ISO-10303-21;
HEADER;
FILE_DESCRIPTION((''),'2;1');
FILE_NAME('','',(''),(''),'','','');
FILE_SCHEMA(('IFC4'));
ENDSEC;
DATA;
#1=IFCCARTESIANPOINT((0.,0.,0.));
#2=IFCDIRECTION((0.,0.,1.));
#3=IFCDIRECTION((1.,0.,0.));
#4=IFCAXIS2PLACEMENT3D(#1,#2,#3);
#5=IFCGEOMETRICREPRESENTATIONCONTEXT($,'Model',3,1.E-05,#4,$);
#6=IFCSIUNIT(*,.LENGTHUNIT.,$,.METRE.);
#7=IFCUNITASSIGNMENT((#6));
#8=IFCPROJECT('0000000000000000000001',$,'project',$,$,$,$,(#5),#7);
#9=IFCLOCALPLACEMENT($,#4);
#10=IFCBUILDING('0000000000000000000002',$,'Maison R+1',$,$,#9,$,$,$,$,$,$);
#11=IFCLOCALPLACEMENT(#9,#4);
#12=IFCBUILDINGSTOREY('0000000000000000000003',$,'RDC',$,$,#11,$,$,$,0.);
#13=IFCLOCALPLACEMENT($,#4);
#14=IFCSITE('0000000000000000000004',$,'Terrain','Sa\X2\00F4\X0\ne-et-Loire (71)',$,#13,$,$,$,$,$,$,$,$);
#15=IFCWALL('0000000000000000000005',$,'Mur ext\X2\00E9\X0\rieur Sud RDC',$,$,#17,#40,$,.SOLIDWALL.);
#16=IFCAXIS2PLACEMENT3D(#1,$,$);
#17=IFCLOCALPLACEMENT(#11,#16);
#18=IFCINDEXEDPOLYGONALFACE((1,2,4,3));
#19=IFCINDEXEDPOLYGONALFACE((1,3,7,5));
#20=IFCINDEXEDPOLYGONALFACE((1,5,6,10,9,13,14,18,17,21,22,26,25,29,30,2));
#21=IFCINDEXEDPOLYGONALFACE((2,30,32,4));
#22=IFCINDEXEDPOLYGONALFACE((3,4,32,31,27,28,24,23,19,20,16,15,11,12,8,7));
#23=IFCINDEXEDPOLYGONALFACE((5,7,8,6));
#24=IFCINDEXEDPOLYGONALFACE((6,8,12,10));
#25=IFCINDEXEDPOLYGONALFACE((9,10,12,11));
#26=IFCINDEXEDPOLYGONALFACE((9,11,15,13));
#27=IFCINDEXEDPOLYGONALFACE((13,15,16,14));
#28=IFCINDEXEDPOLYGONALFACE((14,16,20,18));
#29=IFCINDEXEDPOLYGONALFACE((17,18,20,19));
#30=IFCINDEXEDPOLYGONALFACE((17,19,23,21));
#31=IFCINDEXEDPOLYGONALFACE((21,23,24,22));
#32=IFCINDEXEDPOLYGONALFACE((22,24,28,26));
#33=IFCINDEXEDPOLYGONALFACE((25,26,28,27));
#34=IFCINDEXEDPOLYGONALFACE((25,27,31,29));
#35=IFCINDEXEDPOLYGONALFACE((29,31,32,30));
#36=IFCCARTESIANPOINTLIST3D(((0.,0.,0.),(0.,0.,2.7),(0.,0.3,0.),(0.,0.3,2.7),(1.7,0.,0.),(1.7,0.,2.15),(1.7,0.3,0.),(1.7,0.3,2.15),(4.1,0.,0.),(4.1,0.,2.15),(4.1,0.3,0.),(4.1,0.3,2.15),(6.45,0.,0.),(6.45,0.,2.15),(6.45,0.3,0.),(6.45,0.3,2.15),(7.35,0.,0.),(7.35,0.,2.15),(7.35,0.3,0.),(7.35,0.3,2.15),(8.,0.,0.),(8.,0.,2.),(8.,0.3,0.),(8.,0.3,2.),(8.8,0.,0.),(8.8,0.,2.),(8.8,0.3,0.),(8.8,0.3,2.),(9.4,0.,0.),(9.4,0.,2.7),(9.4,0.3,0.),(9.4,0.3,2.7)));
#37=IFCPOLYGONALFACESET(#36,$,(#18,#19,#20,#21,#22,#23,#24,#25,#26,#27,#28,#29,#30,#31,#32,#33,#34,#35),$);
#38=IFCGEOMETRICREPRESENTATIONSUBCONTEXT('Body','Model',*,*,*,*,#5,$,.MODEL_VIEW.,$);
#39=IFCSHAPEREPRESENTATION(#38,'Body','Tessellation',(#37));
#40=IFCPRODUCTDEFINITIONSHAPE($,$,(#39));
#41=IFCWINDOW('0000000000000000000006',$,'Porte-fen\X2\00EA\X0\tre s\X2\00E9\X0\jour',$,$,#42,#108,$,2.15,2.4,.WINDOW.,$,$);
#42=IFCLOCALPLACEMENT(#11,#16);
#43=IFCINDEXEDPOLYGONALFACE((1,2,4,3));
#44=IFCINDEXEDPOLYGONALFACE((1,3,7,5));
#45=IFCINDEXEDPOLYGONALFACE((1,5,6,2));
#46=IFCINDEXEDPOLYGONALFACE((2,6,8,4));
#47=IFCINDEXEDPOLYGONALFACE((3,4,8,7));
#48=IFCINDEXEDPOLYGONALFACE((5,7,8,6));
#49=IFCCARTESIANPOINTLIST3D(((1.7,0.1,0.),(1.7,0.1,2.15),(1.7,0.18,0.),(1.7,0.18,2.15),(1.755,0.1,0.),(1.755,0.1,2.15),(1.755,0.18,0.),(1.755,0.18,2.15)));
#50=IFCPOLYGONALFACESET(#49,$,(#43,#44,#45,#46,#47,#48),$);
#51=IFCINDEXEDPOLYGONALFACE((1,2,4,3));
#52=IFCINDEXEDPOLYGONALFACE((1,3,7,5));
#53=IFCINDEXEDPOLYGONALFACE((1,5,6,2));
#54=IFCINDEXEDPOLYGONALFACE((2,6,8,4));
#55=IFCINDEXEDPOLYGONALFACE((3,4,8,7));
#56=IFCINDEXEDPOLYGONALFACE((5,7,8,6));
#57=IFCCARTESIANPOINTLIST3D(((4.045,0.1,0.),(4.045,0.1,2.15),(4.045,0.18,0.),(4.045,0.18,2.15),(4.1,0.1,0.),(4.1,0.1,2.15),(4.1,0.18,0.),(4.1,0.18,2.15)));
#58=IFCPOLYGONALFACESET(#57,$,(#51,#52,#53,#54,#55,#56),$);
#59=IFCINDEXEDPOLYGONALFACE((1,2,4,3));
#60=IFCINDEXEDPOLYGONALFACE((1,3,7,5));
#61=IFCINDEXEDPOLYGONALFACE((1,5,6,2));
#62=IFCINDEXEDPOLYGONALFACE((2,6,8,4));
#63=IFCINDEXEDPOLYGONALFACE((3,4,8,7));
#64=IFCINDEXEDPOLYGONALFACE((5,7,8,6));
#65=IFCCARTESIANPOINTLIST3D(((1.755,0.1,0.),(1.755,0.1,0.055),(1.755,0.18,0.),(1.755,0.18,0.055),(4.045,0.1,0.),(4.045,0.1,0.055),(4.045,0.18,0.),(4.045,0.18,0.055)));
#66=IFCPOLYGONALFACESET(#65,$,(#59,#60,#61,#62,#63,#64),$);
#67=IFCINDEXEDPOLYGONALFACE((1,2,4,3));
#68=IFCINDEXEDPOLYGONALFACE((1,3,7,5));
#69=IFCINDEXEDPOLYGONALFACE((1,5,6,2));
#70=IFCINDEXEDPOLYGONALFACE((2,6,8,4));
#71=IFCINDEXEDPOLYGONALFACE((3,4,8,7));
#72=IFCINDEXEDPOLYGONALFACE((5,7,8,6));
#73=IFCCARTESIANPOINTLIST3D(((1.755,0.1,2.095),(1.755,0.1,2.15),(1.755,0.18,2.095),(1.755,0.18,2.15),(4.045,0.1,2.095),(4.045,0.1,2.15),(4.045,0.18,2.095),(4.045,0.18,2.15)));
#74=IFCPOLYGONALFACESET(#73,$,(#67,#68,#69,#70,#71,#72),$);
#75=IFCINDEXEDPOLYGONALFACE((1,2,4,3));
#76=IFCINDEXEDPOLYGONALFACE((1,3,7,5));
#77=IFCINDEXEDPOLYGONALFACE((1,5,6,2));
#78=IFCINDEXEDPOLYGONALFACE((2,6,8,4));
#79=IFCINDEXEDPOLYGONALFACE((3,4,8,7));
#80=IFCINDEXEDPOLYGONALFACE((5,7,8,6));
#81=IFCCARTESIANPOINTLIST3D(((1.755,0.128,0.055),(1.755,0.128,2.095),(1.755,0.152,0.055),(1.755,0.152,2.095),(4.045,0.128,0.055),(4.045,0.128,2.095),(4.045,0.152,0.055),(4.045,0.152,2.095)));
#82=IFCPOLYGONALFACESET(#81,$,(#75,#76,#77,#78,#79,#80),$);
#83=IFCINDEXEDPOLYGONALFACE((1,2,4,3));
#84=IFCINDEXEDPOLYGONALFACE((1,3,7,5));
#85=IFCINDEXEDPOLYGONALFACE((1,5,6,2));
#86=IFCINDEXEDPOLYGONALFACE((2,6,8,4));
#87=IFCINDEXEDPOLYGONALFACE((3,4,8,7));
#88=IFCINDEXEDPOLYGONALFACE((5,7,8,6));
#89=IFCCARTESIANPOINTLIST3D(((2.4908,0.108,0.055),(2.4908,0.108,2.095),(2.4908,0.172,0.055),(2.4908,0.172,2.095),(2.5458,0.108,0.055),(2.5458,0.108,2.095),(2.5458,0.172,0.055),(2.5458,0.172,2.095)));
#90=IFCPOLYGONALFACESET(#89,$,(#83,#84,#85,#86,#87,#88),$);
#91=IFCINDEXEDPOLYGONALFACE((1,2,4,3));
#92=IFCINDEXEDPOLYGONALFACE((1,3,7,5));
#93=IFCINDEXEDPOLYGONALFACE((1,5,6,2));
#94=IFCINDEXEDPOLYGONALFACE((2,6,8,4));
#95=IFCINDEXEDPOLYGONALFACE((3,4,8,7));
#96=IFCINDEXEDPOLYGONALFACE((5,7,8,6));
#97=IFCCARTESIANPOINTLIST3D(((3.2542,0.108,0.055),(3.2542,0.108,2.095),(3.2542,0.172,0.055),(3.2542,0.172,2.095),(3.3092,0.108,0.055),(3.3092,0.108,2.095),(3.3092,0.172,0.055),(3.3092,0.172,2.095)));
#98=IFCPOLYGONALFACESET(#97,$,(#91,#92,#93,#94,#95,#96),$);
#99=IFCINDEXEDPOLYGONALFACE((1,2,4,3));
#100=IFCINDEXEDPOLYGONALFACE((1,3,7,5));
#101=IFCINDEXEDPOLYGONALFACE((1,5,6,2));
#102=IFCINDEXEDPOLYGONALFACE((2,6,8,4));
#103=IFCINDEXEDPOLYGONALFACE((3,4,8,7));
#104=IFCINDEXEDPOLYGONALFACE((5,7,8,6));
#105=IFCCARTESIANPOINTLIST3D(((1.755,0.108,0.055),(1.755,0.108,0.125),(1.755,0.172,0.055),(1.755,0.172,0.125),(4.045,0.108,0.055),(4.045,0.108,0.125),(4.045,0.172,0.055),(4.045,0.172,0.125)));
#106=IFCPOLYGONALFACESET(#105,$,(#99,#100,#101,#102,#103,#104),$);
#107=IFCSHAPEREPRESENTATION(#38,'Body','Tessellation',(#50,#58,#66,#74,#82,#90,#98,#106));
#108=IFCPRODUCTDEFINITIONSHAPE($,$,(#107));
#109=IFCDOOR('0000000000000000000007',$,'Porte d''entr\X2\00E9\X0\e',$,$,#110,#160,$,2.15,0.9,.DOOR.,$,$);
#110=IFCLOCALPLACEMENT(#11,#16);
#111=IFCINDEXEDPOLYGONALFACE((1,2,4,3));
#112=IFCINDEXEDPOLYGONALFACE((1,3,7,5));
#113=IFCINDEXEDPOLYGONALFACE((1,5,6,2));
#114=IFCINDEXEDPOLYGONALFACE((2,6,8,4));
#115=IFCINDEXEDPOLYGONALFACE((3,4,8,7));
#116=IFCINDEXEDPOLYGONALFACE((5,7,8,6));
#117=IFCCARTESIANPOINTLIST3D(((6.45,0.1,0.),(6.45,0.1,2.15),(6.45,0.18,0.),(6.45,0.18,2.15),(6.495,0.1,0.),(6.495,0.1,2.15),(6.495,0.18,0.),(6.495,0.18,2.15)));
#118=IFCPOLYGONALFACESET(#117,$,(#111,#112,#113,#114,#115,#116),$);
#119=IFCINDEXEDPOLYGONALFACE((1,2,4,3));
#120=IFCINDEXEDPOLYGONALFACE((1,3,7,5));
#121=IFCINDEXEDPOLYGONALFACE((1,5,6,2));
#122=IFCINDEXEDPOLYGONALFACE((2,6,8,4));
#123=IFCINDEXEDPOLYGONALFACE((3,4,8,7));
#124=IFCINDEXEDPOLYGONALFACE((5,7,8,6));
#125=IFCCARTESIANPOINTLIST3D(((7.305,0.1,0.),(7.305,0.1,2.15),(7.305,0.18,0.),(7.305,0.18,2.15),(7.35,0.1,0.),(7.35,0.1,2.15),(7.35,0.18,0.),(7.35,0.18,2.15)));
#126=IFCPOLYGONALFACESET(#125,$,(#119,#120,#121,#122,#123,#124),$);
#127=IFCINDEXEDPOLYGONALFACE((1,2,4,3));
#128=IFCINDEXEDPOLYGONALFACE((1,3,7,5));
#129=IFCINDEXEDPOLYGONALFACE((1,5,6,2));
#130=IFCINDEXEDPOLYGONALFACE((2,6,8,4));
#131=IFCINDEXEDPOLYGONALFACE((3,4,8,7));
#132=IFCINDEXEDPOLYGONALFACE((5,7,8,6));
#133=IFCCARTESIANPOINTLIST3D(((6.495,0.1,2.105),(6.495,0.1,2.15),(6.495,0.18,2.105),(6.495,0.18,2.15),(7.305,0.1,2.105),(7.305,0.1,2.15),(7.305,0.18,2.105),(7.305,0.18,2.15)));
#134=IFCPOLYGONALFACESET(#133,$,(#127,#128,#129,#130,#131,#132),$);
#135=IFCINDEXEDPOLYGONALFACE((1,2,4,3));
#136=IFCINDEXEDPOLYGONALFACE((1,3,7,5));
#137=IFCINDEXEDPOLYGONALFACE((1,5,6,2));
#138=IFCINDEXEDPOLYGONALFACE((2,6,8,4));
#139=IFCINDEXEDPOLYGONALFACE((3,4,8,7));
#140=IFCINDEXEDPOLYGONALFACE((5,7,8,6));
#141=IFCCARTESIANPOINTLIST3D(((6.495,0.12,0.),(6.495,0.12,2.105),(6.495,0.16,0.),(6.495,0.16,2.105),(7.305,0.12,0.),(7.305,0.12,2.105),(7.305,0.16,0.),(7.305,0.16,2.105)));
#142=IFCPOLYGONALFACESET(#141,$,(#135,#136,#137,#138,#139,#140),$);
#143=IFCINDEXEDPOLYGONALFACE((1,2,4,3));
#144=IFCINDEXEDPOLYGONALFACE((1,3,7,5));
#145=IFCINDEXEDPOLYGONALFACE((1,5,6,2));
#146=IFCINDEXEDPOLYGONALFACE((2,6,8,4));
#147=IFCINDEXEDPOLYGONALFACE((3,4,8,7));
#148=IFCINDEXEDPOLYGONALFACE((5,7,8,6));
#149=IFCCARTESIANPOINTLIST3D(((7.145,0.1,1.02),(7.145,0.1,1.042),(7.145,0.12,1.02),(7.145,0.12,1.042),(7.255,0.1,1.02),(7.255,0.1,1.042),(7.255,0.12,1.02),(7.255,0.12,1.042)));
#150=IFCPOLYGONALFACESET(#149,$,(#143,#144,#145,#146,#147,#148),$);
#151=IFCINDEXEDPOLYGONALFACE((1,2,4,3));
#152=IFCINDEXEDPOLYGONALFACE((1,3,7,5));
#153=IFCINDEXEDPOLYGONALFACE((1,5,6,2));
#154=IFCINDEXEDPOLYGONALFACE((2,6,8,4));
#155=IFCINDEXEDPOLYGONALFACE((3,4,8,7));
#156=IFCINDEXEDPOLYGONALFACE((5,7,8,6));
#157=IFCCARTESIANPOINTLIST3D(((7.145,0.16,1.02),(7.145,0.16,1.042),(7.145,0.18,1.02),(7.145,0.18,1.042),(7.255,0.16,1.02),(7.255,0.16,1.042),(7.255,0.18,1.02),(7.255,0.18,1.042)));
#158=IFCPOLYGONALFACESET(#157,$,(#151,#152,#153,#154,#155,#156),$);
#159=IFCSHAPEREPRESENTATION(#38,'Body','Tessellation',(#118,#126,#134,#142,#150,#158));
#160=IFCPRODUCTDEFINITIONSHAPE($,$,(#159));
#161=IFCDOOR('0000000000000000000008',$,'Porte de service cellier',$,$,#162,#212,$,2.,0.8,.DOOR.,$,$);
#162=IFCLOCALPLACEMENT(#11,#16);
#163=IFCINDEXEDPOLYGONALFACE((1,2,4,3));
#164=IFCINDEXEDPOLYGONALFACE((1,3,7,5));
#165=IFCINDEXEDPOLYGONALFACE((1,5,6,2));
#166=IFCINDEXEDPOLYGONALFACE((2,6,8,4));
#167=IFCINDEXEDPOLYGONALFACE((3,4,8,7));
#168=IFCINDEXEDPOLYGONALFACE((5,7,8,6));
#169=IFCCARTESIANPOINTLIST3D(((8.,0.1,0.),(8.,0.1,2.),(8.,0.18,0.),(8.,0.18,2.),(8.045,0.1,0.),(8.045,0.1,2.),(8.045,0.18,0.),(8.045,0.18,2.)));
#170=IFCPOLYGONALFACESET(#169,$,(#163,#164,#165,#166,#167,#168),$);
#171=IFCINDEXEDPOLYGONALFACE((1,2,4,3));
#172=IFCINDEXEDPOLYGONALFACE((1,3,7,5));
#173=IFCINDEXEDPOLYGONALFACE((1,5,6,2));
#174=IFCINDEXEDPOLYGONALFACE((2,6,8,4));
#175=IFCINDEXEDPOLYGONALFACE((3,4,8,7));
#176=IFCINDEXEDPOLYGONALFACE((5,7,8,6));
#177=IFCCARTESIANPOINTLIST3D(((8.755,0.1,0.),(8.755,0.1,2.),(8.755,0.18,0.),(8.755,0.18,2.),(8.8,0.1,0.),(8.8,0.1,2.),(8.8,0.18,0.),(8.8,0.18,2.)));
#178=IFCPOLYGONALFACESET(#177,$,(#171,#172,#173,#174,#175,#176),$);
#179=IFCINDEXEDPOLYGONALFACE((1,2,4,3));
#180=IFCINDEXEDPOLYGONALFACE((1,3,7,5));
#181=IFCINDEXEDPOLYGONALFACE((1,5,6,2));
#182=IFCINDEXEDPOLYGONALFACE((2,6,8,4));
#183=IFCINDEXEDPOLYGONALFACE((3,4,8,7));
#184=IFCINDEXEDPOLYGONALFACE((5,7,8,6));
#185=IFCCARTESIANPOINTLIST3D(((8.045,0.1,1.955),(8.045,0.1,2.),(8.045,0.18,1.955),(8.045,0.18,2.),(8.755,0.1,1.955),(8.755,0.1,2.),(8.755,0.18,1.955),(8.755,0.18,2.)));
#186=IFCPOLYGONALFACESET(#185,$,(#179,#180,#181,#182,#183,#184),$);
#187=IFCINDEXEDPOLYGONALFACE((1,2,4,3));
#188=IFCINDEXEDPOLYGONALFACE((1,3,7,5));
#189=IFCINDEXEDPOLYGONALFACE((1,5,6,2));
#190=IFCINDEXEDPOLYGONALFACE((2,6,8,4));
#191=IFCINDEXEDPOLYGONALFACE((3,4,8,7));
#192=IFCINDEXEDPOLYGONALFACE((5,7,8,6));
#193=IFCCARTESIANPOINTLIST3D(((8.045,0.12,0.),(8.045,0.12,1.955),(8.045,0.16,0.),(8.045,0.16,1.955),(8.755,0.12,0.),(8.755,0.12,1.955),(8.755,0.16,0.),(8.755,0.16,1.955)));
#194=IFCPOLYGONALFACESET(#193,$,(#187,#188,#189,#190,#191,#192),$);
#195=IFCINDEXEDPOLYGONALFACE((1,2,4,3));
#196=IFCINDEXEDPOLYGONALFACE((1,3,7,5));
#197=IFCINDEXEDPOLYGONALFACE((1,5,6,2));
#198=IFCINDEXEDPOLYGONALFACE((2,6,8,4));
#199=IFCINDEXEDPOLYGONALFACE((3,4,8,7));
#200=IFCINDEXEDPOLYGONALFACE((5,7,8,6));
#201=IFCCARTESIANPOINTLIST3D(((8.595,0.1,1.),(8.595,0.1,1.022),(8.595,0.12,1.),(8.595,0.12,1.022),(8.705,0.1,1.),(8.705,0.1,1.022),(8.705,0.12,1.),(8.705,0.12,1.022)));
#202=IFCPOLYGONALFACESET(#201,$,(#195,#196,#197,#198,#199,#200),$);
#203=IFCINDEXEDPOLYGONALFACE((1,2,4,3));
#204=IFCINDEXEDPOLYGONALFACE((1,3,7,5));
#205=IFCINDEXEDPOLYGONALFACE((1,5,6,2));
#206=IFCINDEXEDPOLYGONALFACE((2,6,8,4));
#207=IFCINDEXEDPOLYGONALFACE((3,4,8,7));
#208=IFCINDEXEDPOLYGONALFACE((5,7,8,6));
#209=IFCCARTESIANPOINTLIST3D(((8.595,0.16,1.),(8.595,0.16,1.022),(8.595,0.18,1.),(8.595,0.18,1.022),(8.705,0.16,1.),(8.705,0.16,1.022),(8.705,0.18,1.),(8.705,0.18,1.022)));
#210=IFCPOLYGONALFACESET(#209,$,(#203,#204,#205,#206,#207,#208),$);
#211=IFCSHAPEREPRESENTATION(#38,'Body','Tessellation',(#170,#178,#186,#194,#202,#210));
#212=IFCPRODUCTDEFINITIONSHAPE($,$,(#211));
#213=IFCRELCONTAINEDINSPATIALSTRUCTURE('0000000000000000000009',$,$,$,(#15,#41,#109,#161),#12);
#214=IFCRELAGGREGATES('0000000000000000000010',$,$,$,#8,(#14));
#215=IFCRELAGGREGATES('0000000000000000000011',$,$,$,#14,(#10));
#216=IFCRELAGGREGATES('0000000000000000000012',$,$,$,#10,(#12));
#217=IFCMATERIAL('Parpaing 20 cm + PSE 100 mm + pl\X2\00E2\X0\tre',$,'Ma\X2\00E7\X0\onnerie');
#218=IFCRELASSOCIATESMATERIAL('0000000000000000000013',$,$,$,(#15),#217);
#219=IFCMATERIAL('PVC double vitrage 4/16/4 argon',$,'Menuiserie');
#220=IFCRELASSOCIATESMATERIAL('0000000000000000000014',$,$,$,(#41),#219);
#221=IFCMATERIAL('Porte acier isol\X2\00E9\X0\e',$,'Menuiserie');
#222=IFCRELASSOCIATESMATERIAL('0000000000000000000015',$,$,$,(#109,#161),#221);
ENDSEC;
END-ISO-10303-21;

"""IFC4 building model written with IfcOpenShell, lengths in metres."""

from ifc_helpers import new_model, si_unit, frame, frame_2d, origin_with_axes, place, context, subcontext, project, spatial, rectangle, extrude, material, element, fill, save


model = new_model("IFC4")

# Units and contexts
model_context = context("Model", 3, precision=1e-05, world=origin_with_axes())
body_context = subcontext(model_context, "Body", "Model", "MODEL_VIEW")
ifc_project = project(units=[si_unit("LENGTHUNIT", "METRE")], contexts=[model_context])

# Site, building, storey
site_placement = place(None, origin_with_axes())
site = spatial("IfcSite", under=ifc_project, at=site_placement, Name="Terrain", Description="Saône-et-Loire (71)")
building_placement = place(None, origin_with_axes())
building = spatial("IfcBuilding", under=site, at=building_placement, Name="Maison R+1")
storey_placement = place(building_placement, origin_with_axes())
storey = spatial("IfcBuildingStorey", under=building, at=storey_placement, Name="RDC", Elevation=0.0)

# Wall, openings, window, doors
ifc_material_1 = material(Name="Parpaing 20 cm + PSE 100 mm + plâtre", Category="Maçonnerie")
wall_1_placement = place(storey_placement, origin_with_axes())
wall_1 = element("IfcWall", 1, at=wall_1_placement, inside=storey, material=ifc_material_1, Name="Mur extérieur Sud RDC", PredefinedType="SOLIDWALL", context=body_context, shape_type="SweptSolid", body=[
    extrude(rectangle(XDim=9.4, YDim=0.3, at=frame_2d((4.7, 0.15))), origin_with_axes(), (0.0, 0.0, 1.0), 2.7),
])
opening_1_placement = place(storey_placement, frame((1.7, -0.05, 0.0), z_axis=(0.0, 0.0, 1.0), x_axis=(1.0, 0.0, 0.0)))
opening_1 = element("IfcOpeningElement", 2, at=opening_1_placement, cuts=wall_1, context=body_context, shape_type="SweptSolid", body=[
    extrude(rectangle(XDim=2.4, YDim=0.4, at=frame_2d((1.2, 0.2))), origin_with_axes(), (0.0, 0.0, 1.0), 2.15),
])
opening_2_placement = place(storey_placement, frame((6.45, -0.05, 0.0), z_axis=(0.0, 0.0, 1.0), x_axis=(1.0, 0.0, 0.0)))
opening_2 = element("IfcOpeningElement", 3, at=opening_2_placement, cuts=wall_1, context=body_context, shape_type="SweptSolid", body=[
    extrude(rectangle(XDim=0.9, YDim=0.4, at=frame_2d((0.45, 0.2))), origin_with_axes(), (0.0, 0.0, 1.0), 2.15),
])
opening_3_placement = place(storey_placement, frame((8.0, -0.05, 0.0), z_axis=(0.0, 0.0, 1.0), x_axis=(1.0, 0.0, 0.0)))
opening_3 = element("IfcOpeningElement", 4, at=opening_3_placement, cuts=wall_1, context=body_context, shape_type="SweptSolid", body=[
    extrude(rectangle(XDim=0.8, YDim=0.4, at=frame_2d((0.4, 0.2))), origin_with_axes(), (0.0, 0.0, 1.0), 2.0),
])
ifc_material_2 = material(Name="PVC double vitrage 4/16/4 argon", Category="Menuiserie")
window_1_placement = place(storey_placement, frame((1.7, 0.1, 0.0), z_axis=(0.0, 0.0, 1.0), x_axis=(1.0, 0.0, 0.0)))
window_1 = element("IfcWindow", 5, at=window_1_placement, inside=storey, material=ifc_material_2, Name="Porte-fenêtre séjour", OverallHeight=2.15, OverallWidth=2.4, PredefinedType="WINDOW", context=body_context, shape_type="SweptSolid", body=[
    extrude(rectangle(XDim=0.055, YDim=0.08, at=frame_2d((0.0275, 0.04))), origin_with_axes(), (0.0, 0.0, 1.0), 2.15),
    extrude(rectangle(XDim=0.055, YDim=0.08, at=frame_2d((0.0275, 0.04))), frame((2.345, 0.0, 0.0), z_axis=(0.0, 0.0, 1.0), x_axis=(1.0, 0.0, 0.0)), (0.0, 0.0, 1.0), 2.15),
    extrude(rectangle(XDim=2.29, YDim=0.08, at=frame_2d((1.145, 0.04))), frame((0.055, 0.0, 0.0), z_axis=(0.0, 0.0, 1.0), x_axis=(1.0, 0.0, 0.0)), (0.0, 0.0, 1.0), 0.055),
    extrude(rectangle(XDim=2.29, YDim=0.08, at=frame_2d((1.145, 0.04))), frame((0.055, 0.0, 2.095), z_axis=(0.0, 0.0, 1.0), x_axis=(1.0, 0.0, 0.0)), (0.0, 0.0, 1.0), 0.055),
    extrude(rectangle(XDim=2.29, YDim=0.024, at=frame_2d((1.145, 0.012))), frame((0.055, 0.028, 0.055), z_axis=(0.0, 0.0, 1.0), x_axis=(1.0, 0.0, 0.0)), (0.0, 0.0, 1.0), 2.04),
    extrude(rectangle(XDim=0.055, YDim=0.064, at=frame_2d((0.0275, 0.032))), frame((0.7908, 0.008, 0.055), z_axis=(0.0, 0.0, 1.0), x_axis=(1.0, 0.0, 0.0)), (0.0, 0.0, 1.0), 2.04),
    extrude(rectangle(XDim=0.055, YDim=0.064, at=frame_2d((0.0275, 0.032))), frame((1.5542, 0.008, 0.055), z_axis=(0.0, 0.0, 1.0), x_axis=(1.0, 0.0, 0.0)), (0.0, 0.0, 1.0), 2.04),
    extrude(rectangle(XDim=2.29, YDim=0.064, at=frame_2d((1.145, 0.032))), frame((0.055, 0.008, 0.055), z_axis=(0.0, 0.0, 1.0), x_axis=(1.0, 0.0, 0.0)), (0.0, 0.0, 1.0), 0.07),
])
fill(opening_1, window_1)
ifc_material_3 = material(Name="Porte acier isolée", Category="Menuiserie")
door_1_placement = place(storey_placement, frame((6.45, 0.1, 0.0), z_axis=(0.0, 0.0, 1.0), x_axis=(1.0, 0.0, 0.0)))
door_1 = element("IfcDoor", 6, at=door_1_placement, inside=storey, material=ifc_material_3, Name="Porte d'entrée", OverallHeight=2.15, OverallWidth=0.9, PredefinedType="DOOR", context=body_context, shape_type="SweptSolid", body=[
    extrude(rectangle(XDim=0.045, YDim=0.08, at=frame_2d((0.0225, 0.04))), origin_with_axes(), (0.0, 0.0, 1.0), 2.15),
    extrude(rectangle(XDim=0.045, YDim=0.08, at=frame_2d((0.0225, 0.04))), frame((0.855, 0.0, 0.0), z_axis=(0.0, 0.0, 1.0), x_axis=(1.0, 0.0, 0.0)), (0.0, 0.0, 1.0), 2.15),
    extrude(rectangle(XDim=0.81, YDim=0.08, at=frame_2d((0.405, 0.04))), frame((0.045, 0.0, 2.105), z_axis=(0.0, 0.0, 1.0), x_axis=(1.0, 0.0, 0.0)), (0.0, 0.0, 1.0), 0.045),
    extrude(rectangle(XDim=0.81, YDim=0.04, at=frame_2d((0.405, 0.02))), frame((0.045, 0.02, 0.0), z_axis=(0.0, 0.0, 1.0), x_axis=(1.0, 0.0, 0.0)), (0.0, 0.0, 1.0), 2.105),
    extrude(rectangle(XDim=0.11, YDim=0.02, at=frame_2d((0.055, 0.01))), frame((0.695, 0.0, 1.02), z_axis=(0.0, 0.0, 1.0), x_axis=(1.0, 0.0, 0.0)), (0.0, 0.0, 1.0), 0.022),
    extrude(rectangle(XDim=0.11, YDim=0.02, at=frame_2d((0.055, 0.01))), frame((0.695, 0.06, 1.02), z_axis=(0.0, 0.0, 1.0), x_axis=(1.0, 0.0, 0.0)), (0.0, 0.0, 1.0), 0.022),
])
fill(opening_2, door_1)
door_2_placement = place(storey_placement, frame((8.0, 0.1, 0.0), z_axis=(0.0, 0.0, 1.0), x_axis=(1.0, 0.0, 0.0)))
door_2 = element("IfcDoor", 7, at=door_2_placement, inside=storey, material=ifc_material_3, Name="Porte de service cellier", OverallHeight=2.0, OverallWidth=0.8, PredefinedType="DOOR", context=body_context, shape_type="SweptSolid", body=[
    extrude(rectangle(XDim=0.045, YDim=0.08, at=frame_2d((0.0225, 0.04))), origin_with_axes(), (0.0, 0.0, 1.0), 2.0),
    extrude(rectangle(XDim=0.045, YDim=0.08, at=frame_2d((0.0225, 0.04))), frame((0.755, 0.0, 0.0), z_axis=(0.0, 0.0, 1.0), x_axis=(1.0, 0.0, 0.0)), (0.0, 0.0, 1.0), 2.0),
    extrude(rectangle(XDim=0.71, YDim=0.08, at=frame_2d((0.355, 0.04))), frame((0.045, 0.0, 1.955), z_axis=(0.0, 0.0, 1.0), x_axis=(1.0, 0.0, 0.0)), (0.0, 0.0, 1.0), 0.045),
    extrude(rectangle(XDim=0.71, YDim=0.04, at=frame_2d((0.355, 0.02))), frame((0.045, 0.02, 0.0), z_axis=(0.0, 0.0, 1.0), x_axis=(1.0, 0.0, 0.0)), (0.0, 0.0, 1.0), 1.955),
    extrude(rectangle(XDim=0.11, YDim=0.02, at=frame_2d((0.055, 0.01))), frame((0.595, 0.0, 1.0), z_axis=(0.0, 0.0, 1.0), x_axis=(1.0, 0.0, 0.0)), (0.0, 0.0, 1.0), 0.022),
    extrude(rectangle(XDim=0.11, YDim=0.02, at=frame_2d((0.055, 0.01))), frame((0.595, 0.06, 1.0), z_axis=(0.0, 0.0, 1.0), x_axis=(1.0, 0.0, 0.0)), (0.0, 0.0, 1.0), 0.022),
])
fill(opening_3, door_2)

save(model, "model.ifc")
